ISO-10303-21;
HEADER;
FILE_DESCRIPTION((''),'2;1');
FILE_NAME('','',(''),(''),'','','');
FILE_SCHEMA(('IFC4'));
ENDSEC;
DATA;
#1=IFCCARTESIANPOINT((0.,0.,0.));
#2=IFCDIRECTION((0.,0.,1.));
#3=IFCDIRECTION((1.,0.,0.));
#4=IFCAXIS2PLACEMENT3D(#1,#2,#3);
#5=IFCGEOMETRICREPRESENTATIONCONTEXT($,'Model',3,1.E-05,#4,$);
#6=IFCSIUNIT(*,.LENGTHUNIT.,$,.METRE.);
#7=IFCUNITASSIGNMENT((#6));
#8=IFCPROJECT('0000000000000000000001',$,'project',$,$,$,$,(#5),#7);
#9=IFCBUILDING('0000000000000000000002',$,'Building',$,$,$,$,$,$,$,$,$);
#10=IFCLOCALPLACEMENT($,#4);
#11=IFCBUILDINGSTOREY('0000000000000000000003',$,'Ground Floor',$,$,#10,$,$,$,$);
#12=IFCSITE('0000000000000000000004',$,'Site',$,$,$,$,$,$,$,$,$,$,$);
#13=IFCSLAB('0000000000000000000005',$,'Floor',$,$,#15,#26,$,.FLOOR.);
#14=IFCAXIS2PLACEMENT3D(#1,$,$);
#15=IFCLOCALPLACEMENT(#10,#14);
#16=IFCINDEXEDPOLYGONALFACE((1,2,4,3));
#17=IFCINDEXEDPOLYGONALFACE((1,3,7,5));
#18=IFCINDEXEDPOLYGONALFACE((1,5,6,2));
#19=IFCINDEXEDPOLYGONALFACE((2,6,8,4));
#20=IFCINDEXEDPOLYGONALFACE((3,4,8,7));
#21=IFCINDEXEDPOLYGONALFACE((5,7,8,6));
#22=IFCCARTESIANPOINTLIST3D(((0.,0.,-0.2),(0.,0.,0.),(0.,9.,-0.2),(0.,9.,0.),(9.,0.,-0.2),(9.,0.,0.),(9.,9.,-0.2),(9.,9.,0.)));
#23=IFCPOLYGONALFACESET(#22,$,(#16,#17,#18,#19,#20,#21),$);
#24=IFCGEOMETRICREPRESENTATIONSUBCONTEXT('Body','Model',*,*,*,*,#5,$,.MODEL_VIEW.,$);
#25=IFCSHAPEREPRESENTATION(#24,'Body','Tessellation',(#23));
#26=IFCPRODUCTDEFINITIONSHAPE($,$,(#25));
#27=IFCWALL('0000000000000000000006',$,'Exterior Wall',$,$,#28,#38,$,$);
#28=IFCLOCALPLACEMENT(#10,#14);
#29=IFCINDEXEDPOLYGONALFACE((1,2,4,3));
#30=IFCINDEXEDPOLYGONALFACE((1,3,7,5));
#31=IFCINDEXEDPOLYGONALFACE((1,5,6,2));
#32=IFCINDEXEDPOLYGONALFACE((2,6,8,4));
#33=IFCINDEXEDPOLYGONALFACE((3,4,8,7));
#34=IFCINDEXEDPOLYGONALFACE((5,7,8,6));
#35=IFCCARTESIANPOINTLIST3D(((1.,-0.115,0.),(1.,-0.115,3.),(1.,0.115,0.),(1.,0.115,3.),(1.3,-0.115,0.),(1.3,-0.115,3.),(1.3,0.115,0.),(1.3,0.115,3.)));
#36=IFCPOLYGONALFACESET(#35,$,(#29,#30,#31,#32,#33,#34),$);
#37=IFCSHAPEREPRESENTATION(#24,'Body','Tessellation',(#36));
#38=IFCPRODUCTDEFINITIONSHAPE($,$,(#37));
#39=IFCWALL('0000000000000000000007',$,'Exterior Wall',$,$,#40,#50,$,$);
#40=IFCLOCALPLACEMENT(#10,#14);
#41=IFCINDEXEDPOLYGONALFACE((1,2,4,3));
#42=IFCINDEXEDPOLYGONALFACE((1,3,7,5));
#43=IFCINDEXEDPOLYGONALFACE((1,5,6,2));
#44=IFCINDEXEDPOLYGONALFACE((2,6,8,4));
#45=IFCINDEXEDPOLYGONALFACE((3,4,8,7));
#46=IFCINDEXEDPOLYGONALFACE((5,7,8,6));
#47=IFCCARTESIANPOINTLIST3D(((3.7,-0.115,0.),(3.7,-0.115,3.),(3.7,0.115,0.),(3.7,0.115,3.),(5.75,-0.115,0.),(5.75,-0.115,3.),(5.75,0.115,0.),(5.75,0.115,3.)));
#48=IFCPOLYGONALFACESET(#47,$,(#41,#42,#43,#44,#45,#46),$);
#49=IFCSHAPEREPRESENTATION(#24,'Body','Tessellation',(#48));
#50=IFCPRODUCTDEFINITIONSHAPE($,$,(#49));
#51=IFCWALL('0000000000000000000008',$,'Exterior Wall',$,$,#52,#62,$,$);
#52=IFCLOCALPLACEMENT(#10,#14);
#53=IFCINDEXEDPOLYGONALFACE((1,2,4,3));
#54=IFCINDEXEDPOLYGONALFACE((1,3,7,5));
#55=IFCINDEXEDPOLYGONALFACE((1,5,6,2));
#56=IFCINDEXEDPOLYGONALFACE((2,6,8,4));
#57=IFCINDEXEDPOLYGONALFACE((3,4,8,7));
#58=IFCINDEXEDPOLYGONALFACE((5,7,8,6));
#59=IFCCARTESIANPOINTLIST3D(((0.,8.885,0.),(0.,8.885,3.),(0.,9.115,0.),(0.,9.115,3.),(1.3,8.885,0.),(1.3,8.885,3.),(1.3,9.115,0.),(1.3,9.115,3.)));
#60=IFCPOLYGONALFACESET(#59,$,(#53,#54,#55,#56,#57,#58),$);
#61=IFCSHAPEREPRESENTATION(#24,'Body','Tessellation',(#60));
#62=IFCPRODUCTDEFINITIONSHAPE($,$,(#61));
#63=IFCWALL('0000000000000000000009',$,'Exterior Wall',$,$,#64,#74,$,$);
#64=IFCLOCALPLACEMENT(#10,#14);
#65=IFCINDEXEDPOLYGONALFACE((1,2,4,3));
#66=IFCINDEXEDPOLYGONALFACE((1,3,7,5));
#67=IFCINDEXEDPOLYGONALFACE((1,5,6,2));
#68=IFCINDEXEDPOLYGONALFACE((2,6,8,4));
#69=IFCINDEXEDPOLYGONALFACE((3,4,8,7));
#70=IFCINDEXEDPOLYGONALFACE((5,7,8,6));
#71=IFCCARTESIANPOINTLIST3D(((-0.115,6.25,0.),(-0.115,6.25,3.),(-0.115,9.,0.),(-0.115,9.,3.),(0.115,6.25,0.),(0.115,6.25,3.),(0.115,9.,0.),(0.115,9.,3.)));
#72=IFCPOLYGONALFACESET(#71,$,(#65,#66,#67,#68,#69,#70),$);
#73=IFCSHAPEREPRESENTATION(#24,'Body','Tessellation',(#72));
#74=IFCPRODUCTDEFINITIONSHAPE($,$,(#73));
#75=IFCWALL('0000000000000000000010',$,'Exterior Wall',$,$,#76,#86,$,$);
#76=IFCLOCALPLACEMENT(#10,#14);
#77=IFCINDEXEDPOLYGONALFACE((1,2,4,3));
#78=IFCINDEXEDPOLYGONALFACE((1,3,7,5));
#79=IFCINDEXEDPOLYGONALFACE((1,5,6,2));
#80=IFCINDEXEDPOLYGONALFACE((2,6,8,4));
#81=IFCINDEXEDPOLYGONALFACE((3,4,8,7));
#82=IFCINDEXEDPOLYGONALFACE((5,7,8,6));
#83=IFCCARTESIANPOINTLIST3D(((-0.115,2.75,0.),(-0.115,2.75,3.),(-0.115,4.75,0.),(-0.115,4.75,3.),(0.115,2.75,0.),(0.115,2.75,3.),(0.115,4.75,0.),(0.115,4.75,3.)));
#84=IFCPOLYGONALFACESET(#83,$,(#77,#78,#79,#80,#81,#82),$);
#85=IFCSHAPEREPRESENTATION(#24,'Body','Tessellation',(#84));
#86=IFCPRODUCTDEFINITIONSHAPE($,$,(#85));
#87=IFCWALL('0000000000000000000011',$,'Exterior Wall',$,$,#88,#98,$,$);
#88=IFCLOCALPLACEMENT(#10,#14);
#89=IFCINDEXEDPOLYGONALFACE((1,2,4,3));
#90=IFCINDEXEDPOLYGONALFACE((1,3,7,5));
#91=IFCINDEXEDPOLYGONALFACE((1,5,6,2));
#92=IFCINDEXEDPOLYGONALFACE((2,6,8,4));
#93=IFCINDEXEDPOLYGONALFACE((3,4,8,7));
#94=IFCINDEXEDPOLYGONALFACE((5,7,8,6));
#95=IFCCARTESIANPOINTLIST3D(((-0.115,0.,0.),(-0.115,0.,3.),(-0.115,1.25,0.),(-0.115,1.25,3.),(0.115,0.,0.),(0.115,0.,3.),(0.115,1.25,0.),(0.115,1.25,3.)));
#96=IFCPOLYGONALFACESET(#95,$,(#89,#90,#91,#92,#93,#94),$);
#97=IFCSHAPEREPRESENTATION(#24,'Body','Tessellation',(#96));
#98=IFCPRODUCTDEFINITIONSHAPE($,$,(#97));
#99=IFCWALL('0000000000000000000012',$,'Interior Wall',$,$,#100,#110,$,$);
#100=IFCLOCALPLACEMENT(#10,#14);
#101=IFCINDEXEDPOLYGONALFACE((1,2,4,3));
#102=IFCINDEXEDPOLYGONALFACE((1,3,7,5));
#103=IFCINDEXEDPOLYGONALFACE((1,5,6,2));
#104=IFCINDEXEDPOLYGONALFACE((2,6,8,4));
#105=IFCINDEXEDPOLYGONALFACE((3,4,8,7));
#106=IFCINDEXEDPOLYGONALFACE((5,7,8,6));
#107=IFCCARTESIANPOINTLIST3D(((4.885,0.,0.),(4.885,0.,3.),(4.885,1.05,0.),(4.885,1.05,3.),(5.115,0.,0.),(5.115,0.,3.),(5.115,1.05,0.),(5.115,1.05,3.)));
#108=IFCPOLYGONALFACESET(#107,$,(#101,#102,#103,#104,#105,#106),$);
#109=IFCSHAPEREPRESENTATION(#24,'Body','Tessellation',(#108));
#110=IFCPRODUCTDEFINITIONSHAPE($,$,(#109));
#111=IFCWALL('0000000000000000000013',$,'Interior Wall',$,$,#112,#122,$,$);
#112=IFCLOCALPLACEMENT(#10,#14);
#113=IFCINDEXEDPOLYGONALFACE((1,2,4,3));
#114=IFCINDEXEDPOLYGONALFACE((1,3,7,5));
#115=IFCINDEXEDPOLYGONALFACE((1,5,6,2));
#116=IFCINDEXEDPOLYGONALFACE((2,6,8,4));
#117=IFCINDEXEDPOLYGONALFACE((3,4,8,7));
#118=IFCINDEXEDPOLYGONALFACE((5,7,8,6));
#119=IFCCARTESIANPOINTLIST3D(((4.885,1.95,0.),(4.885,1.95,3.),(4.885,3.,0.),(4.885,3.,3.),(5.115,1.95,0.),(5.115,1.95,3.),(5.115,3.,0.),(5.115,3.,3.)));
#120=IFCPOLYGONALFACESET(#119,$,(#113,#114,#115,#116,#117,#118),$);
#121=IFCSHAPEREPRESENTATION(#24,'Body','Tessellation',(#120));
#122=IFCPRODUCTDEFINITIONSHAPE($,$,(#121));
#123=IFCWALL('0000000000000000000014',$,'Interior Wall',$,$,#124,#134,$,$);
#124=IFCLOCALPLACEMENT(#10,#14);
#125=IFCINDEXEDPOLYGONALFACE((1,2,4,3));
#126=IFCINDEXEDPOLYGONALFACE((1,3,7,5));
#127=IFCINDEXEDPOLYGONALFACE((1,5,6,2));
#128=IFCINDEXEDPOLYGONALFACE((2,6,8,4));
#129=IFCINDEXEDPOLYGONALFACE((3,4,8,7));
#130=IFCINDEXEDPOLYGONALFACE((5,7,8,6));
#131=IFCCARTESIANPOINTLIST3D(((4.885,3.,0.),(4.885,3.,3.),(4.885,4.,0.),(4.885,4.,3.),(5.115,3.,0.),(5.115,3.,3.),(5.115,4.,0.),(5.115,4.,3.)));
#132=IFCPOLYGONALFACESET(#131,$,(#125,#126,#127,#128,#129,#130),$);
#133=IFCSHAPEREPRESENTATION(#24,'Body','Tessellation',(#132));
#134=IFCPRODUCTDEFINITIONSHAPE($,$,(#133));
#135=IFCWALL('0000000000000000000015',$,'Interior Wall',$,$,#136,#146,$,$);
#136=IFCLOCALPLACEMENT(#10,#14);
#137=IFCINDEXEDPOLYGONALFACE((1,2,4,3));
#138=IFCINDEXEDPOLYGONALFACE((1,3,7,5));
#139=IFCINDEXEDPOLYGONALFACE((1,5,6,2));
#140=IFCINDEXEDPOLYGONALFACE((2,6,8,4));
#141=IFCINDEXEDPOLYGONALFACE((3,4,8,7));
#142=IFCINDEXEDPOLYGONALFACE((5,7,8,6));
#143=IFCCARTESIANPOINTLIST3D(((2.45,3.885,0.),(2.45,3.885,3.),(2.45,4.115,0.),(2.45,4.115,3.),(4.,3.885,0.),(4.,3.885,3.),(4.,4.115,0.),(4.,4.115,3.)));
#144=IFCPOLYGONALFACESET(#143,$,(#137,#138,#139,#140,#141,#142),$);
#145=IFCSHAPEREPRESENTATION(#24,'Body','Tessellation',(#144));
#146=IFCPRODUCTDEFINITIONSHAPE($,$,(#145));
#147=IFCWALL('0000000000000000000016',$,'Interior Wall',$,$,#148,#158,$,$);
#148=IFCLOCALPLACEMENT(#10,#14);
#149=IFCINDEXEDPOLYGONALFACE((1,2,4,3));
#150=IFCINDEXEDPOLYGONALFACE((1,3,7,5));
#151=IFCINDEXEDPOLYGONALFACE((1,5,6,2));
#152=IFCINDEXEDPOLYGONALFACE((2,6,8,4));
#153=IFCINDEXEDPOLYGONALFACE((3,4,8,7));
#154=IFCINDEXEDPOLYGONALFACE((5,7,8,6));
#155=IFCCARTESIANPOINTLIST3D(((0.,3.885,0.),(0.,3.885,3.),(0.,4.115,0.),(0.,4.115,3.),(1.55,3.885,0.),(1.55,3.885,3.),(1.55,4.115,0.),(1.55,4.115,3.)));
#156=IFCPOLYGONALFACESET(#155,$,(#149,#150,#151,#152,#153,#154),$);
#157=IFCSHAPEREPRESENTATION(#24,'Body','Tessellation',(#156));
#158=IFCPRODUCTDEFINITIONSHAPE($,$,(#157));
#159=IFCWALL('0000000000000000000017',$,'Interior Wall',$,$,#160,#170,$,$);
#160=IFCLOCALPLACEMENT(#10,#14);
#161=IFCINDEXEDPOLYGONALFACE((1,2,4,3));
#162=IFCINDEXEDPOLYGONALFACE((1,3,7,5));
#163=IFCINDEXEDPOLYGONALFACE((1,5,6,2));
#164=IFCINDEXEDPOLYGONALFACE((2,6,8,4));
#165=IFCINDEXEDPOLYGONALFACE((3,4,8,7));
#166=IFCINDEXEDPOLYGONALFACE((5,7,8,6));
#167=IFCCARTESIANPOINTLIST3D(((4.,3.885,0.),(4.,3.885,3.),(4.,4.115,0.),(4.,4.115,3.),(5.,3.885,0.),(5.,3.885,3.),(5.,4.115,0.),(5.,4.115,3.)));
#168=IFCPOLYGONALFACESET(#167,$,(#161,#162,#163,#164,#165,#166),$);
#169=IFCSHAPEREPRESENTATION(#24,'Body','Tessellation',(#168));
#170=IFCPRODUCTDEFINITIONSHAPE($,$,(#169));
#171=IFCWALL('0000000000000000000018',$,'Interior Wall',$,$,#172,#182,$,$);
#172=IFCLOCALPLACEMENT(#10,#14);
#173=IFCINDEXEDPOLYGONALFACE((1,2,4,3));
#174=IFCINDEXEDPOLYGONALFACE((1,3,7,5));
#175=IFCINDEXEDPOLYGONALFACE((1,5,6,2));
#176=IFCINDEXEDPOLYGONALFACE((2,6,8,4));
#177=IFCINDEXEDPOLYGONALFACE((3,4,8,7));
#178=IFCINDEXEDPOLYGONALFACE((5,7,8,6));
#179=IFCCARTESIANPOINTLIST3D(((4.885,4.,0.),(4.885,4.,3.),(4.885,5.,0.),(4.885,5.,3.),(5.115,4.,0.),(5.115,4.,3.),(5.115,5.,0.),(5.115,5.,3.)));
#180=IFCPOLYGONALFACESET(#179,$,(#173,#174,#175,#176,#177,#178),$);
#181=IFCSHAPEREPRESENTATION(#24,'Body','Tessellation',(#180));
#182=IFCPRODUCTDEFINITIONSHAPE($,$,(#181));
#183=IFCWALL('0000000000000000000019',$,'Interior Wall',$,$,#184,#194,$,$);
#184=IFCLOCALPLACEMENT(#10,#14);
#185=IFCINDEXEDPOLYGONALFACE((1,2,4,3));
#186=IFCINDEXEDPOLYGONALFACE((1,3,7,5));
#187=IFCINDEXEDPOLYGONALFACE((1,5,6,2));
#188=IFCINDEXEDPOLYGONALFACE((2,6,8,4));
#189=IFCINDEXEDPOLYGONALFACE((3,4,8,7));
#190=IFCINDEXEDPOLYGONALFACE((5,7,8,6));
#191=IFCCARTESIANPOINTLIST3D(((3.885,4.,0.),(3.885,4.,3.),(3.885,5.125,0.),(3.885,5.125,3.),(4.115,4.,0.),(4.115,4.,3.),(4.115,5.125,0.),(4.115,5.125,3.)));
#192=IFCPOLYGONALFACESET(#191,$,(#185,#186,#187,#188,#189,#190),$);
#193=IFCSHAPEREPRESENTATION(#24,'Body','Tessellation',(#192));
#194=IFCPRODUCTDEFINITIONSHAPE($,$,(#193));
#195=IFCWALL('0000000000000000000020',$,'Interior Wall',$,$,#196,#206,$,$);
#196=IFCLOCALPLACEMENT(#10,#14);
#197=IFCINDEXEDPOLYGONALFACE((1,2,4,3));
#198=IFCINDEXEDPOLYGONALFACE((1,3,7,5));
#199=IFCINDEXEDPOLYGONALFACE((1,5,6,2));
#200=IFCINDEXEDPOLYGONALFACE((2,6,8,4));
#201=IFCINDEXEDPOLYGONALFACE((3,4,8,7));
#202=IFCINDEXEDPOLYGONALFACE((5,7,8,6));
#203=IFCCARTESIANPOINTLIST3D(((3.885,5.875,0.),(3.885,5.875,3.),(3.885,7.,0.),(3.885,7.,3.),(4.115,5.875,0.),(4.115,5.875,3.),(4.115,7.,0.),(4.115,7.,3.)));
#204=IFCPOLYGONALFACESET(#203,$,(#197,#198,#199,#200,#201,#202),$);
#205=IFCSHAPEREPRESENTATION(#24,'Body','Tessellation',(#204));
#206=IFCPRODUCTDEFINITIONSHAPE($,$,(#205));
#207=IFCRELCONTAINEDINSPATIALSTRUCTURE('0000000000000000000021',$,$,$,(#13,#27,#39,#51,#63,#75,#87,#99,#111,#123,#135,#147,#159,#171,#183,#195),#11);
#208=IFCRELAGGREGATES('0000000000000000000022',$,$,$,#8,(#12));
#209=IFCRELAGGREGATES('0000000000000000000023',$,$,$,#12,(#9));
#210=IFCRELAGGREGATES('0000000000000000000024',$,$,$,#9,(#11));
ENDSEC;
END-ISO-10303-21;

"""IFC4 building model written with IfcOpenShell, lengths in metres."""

from ifc_helpers import new_model, si_unit, frame, origin_with_axes, place, context, subcontext, project, spatial, indexed_curve, outline, extrude, element, save


model = new_model("IFC4")

# Units and contexts
model_context = context("Model", 3, precision=1e-05, world=origin_with_axes())
body_context = subcontext(model_context, "Body", "Model", "MODEL_VIEW")
ifc_project = project(units=[si_unit("LENGTHUNIT", "METRE")], contexts=[model_context])

# Site, building, storey
site = spatial("IfcSite", under=ifc_project, Name="Site")
building = spatial("IfcBuilding", under=site, Name="Building")
storey_placement = place(None, origin_with_axes())
storey = spatial("IfcBuildingStorey", under=building, at=storey_placement, Name="Ground Floor")

# Slab
slab_placement = place(storey_placement, frame((0.0, 0.0, -0.2), z_axis=(0.0, 0.0, 1.0), x_axis=(1.0, 0.0, 0.0)))
element("IfcSlab", 1, at=slab_placement, inside=storey, Name="Floor", PredefinedType="FLOOR", context=body_context, shape_type="SweptSolid", body=[
    extrude(outline(indexed_curve([(0.0, 0.0), (9.0, 0.0), (9.0, 9.0), (0.0, 9.0)])), None, (0.0, 0.0, 1.0), 0.2),
])

# Walls
wall_1_placement = place(storey_placement, frame((1.0, 0.0, 0.0), z_axis=(0.0, 0.0, 1.0), x_axis=(1.0, 0.0, 0.0)))
element("IfcWall", 2, at=wall_1_placement, inside=storey, Name="Exterior Wall", context=body_context, shape_type="SweptSolid", body=[
    extrude(outline(indexed_curve([(0.0, 0.0), (0.0, 0.23), (0.3, 0.23), (0.3, 0.0), (0.0, 0.0)], self_intersect=False)), frame((0.0, -0.115, 0.0), z_axis=(0.0, 0.0, 1.0), x_axis=(1.0, 0.0, 0.0)), (0.0, 0.0, 1.0), 3.0),
])
wall_2_placement = place(storey_placement, frame((3.7, 0.0, 0.0), z_axis=(0.0, 0.0, 1.0), x_axis=(1.0, 0.0, 0.0)))
element("IfcWall", 3, at=wall_2_placement, inside=storey, Name="Exterior Wall", context=body_context, shape_type="SweptSolid", body=[
    extrude(outline(indexed_curve([(0.0, 0.0), (0.0, 0.23), (2.05, 0.23), (2.05, 0.0), (0.0, 0.0)], self_intersect=False)), frame((0.0, -0.115, 0.0), z_axis=(0.0, 0.0, 1.0), x_axis=(1.0, 0.0, 0.0)), (0.0, 0.0, 1.0), 3.0),
])
wall_3_placement = place(storey_placement, frame((1.3, 9.0, 0.0), z_axis=(0.0, 0.0, 1.0), x_axis=(-1.0, 0.0, 0.0)))
element("IfcWall", 4, at=wall_3_placement, inside=storey, Name="Exterior Wall", context=body_context, shape_type="SweptSolid", body=[
    extrude(outline(indexed_curve([(0.0, 0.0), (0.0, 0.23), (1.3, 0.23), (1.3, 0.0), (0.0, 0.0)], self_intersect=False)), frame((0.0, -0.115, 0.0), z_axis=(0.0, 0.0, 1.0), x_axis=(1.0, 0.0, 0.0)), (0.0, 0.0, 1.0), 3.0),
])
wall_4_placement = place(storey_placement, frame((0.0, 9.0, 0.0), z_axis=(0.0, 0.0, 1.0), x_axis=(0.0, -1.0, 0.0)))
element("IfcWall", 5, at=wall_4_placement, inside=storey, Name="Exterior Wall", context=body_context, shape_type="SweptSolid", body=[
    extrude(outline(indexed_curve([(0.0, 0.0), (0.0, 0.23), (2.75, 0.23), (2.75, 0.0), (0.0, 0.0)], self_intersect=False)), frame((0.0, -0.115, 0.0), z_axis=(0.0, 0.0, 1.0), x_axis=(1.0, 0.0, 0.0)), (0.0, 0.0, 1.0), 3.0),
])
wall_5_placement = place(storey_placement, frame((0.0, 4.75, 0.0), z_axis=(0.0, 0.0, 1.0), x_axis=(0.0, -1.0, 0.0)))
element("IfcWall", 6, at=wall_5_placement, inside=storey, Name="Exterior Wall", context=body_context, shape_type="SweptSolid", body=[
    extrude(outline(indexed_curve([(0.0, 0.0), (0.0, 0.23), (2.0, 0.23), (2.0, 0.0), (0.0, 0.0)], self_intersect=False)), frame((0.0, -0.115, 0.0), z_axis=(0.0, 0.0, 1.0), x_axis=(1.0, 0.0, 0.0)), (0.0, 0.0, 1.0), 3.0),
])
wall_6_placement = place(storey_placement, frame((0.0, 1.25, 0.0), z_axis=(0.0, 0.0, 1.0), x_axis=(0.0, -1.0, 0.0)))
element("IfcWall", 7, at=wall_6_placement, inside=storey, Name="Exterior Wall", context=body_context, shape_type="SweptSolid", body=[
    extrude(outline(indexed_curve([(0.0, 0.0), (0.0, 0.23), (1.25, 0.23), (1.25, 0.0), (0.0, 0.0)], self_intersect=False)), frame((0.0, -0.115, 0.0), z_axis=(0.0, 0.0, 1.0), x_axis=(1.0, 0.0, 0.0)), (0.0, 0.0, 1.0), 3.0),
])
for number, where, z_axis, x_axis, name in (
    (8, (5.0, 0.0, 0.0), (0.0, 0.0, 1.0), (0.0, 1.0, 0.0), "Interior Wall"),
    (9, (5.0, 1.95, 0.0), (0.0, 0.0, 1.0), (0.0, 1.0, 0.0), "Interior Wall"),
):
    element("IfcWall", number, at=place(storey_placement, frame(where, z_axis=z_axis, x_axis=x_axis)), inside=storey, Name=name, context=body_context, shape_type="SweptSolid", body=[
        extrude(outline(indexed_curve([(0.0, 0.0), (0.0, 0.23), (1.05, 0.23), (1.05, 0.0), (0.0, 0.0)], self_intersect=False)), frame((0.0, -0.115, 0.0), z_axis=(0.0, 0.0, 1.0), x_axis=(1.0, 0.0, 0.0)), (0.0, 0.0, 1.0), 3.0),
    ])
wall_7_placement = place(storey_placement, frame((5.0, 3.0, 0.0), z_axis=(0.0, 0.0, 1.0), x_axis=(0.0, 1.0, 0.0)))
element("IfcWall", 10, at=wall_7_placement, inside=storey, Name="Interior Wall", context=body_context, shape_type="SweptSolid", body=[
    extrude(outline(indexed_curve([(0.0, 0.0), (0.0, 0.23), (1.0, 0.23), (1.0, 0.0), (0.0, 0.0)], self_intersect=False)), frame((0.0, -0.115, 0.0), z_axis=(0.0, 0.0, 1.0), x_axis=(1.0, 0.0, 0.0)), (0.0, 0.0, 1.0), 3.0),
])
for number, where, z_axis, x_axis, name in (
    (11, (4.0, 4.0, 0.0), (0.0, 0.0, 1.0), (-1.0, 0.0, 0.0), "Interior Wall"),
    (12, (1.55, 4.0, 0.0), (0.0, 0.0, 1.0), (-1.0, 0.0, 0.0), "Interior Wall"),
):
    element("IfcWall", number, at=place(storey_placement, frame(where, z_axis=z_axis, x_axis=x_axis)), inside=storey, Name=name, context=body_context, shape_type="SweptSolid", body=[
        extrude(outline(indexed_curve([(0.0, 0.0), (0.0, 0.23), (1.55, 0.23), (1.55, 0.0), (0.0, 0.0)], self_intersect=False)), frame((0.0, -0.115, 0.0), z_axis=(0.0, 0.0, 1.0), x_axis=(1.0, 0.0, 0.0)), (0.0, 0.0, 1.0), 3.0),
    ])
for number, where, z_axis, x_axis, name in (
    (13, (5.0, 4.0, 0.0), (0.0, 0.0, 1.0), (-1.0, 0.0, 0.0), "Interior Wall"),
    (14, (5.0, 5.0, 0.0), (0.0, 0.0, 1.0), (0.0, -1.0, 0.0), "Interior Wall"),
):
    element("IfcWall", number, at=place(storey_placement, frame(where, z_axis=z_axis, x_axis=x_axis)), inside=storey, Name=name, context=body_context, shape_type="SweptSolid", body=[
        extrude(outline(indexed_curve([(0.0, 0.0), (0.0, 0.23), (1.0, 0.23), (1.0, 0.0), (0.0, 0.0)], self_intersect=False)), frame((0.0, -0.115, 0.0), z_axis=(0.0, 0.0, 1.0), x_axis=(1.0, 0.0, 0.0)), (0.0, 0.0, 1.0), 3.0),
    ])
for number, where, z_axis, x_axis, name in (
    (15, (4.0, 4.0, 0.0), (0.0, 0.0, 1.0), (0.0, 1.0, 0.0), "Interior Wall"),
    (16, (4.0, 5.875, 0.0), (0.0, 0.0, 1.0), (0.0, 1.0, 0.0), "Interior Wall"),
):
    element("IfcWall", number, at=place(storey_placement, frame(where, z_axis=z_axis, x_axis=x_axis)), inside=storey, Name=name, context=body_context, shape_type="SweptSolid", body=[
        extrude(outline(indexed_curve([(0.0, 0.0), (0.0, 0.23), (1.125, 0.23), (1.125, 0.0), (0.0, 0.0)], self_intersect=False)), frame((0.0, -0.115, 0.0), z_axis=(0.0, 0.0, 1.0), x_axis=(1.0, 0.0, 0.0)), (0.0, 0.0, 1.0), 3.0),
    ])

save(model, "model.ifc")
